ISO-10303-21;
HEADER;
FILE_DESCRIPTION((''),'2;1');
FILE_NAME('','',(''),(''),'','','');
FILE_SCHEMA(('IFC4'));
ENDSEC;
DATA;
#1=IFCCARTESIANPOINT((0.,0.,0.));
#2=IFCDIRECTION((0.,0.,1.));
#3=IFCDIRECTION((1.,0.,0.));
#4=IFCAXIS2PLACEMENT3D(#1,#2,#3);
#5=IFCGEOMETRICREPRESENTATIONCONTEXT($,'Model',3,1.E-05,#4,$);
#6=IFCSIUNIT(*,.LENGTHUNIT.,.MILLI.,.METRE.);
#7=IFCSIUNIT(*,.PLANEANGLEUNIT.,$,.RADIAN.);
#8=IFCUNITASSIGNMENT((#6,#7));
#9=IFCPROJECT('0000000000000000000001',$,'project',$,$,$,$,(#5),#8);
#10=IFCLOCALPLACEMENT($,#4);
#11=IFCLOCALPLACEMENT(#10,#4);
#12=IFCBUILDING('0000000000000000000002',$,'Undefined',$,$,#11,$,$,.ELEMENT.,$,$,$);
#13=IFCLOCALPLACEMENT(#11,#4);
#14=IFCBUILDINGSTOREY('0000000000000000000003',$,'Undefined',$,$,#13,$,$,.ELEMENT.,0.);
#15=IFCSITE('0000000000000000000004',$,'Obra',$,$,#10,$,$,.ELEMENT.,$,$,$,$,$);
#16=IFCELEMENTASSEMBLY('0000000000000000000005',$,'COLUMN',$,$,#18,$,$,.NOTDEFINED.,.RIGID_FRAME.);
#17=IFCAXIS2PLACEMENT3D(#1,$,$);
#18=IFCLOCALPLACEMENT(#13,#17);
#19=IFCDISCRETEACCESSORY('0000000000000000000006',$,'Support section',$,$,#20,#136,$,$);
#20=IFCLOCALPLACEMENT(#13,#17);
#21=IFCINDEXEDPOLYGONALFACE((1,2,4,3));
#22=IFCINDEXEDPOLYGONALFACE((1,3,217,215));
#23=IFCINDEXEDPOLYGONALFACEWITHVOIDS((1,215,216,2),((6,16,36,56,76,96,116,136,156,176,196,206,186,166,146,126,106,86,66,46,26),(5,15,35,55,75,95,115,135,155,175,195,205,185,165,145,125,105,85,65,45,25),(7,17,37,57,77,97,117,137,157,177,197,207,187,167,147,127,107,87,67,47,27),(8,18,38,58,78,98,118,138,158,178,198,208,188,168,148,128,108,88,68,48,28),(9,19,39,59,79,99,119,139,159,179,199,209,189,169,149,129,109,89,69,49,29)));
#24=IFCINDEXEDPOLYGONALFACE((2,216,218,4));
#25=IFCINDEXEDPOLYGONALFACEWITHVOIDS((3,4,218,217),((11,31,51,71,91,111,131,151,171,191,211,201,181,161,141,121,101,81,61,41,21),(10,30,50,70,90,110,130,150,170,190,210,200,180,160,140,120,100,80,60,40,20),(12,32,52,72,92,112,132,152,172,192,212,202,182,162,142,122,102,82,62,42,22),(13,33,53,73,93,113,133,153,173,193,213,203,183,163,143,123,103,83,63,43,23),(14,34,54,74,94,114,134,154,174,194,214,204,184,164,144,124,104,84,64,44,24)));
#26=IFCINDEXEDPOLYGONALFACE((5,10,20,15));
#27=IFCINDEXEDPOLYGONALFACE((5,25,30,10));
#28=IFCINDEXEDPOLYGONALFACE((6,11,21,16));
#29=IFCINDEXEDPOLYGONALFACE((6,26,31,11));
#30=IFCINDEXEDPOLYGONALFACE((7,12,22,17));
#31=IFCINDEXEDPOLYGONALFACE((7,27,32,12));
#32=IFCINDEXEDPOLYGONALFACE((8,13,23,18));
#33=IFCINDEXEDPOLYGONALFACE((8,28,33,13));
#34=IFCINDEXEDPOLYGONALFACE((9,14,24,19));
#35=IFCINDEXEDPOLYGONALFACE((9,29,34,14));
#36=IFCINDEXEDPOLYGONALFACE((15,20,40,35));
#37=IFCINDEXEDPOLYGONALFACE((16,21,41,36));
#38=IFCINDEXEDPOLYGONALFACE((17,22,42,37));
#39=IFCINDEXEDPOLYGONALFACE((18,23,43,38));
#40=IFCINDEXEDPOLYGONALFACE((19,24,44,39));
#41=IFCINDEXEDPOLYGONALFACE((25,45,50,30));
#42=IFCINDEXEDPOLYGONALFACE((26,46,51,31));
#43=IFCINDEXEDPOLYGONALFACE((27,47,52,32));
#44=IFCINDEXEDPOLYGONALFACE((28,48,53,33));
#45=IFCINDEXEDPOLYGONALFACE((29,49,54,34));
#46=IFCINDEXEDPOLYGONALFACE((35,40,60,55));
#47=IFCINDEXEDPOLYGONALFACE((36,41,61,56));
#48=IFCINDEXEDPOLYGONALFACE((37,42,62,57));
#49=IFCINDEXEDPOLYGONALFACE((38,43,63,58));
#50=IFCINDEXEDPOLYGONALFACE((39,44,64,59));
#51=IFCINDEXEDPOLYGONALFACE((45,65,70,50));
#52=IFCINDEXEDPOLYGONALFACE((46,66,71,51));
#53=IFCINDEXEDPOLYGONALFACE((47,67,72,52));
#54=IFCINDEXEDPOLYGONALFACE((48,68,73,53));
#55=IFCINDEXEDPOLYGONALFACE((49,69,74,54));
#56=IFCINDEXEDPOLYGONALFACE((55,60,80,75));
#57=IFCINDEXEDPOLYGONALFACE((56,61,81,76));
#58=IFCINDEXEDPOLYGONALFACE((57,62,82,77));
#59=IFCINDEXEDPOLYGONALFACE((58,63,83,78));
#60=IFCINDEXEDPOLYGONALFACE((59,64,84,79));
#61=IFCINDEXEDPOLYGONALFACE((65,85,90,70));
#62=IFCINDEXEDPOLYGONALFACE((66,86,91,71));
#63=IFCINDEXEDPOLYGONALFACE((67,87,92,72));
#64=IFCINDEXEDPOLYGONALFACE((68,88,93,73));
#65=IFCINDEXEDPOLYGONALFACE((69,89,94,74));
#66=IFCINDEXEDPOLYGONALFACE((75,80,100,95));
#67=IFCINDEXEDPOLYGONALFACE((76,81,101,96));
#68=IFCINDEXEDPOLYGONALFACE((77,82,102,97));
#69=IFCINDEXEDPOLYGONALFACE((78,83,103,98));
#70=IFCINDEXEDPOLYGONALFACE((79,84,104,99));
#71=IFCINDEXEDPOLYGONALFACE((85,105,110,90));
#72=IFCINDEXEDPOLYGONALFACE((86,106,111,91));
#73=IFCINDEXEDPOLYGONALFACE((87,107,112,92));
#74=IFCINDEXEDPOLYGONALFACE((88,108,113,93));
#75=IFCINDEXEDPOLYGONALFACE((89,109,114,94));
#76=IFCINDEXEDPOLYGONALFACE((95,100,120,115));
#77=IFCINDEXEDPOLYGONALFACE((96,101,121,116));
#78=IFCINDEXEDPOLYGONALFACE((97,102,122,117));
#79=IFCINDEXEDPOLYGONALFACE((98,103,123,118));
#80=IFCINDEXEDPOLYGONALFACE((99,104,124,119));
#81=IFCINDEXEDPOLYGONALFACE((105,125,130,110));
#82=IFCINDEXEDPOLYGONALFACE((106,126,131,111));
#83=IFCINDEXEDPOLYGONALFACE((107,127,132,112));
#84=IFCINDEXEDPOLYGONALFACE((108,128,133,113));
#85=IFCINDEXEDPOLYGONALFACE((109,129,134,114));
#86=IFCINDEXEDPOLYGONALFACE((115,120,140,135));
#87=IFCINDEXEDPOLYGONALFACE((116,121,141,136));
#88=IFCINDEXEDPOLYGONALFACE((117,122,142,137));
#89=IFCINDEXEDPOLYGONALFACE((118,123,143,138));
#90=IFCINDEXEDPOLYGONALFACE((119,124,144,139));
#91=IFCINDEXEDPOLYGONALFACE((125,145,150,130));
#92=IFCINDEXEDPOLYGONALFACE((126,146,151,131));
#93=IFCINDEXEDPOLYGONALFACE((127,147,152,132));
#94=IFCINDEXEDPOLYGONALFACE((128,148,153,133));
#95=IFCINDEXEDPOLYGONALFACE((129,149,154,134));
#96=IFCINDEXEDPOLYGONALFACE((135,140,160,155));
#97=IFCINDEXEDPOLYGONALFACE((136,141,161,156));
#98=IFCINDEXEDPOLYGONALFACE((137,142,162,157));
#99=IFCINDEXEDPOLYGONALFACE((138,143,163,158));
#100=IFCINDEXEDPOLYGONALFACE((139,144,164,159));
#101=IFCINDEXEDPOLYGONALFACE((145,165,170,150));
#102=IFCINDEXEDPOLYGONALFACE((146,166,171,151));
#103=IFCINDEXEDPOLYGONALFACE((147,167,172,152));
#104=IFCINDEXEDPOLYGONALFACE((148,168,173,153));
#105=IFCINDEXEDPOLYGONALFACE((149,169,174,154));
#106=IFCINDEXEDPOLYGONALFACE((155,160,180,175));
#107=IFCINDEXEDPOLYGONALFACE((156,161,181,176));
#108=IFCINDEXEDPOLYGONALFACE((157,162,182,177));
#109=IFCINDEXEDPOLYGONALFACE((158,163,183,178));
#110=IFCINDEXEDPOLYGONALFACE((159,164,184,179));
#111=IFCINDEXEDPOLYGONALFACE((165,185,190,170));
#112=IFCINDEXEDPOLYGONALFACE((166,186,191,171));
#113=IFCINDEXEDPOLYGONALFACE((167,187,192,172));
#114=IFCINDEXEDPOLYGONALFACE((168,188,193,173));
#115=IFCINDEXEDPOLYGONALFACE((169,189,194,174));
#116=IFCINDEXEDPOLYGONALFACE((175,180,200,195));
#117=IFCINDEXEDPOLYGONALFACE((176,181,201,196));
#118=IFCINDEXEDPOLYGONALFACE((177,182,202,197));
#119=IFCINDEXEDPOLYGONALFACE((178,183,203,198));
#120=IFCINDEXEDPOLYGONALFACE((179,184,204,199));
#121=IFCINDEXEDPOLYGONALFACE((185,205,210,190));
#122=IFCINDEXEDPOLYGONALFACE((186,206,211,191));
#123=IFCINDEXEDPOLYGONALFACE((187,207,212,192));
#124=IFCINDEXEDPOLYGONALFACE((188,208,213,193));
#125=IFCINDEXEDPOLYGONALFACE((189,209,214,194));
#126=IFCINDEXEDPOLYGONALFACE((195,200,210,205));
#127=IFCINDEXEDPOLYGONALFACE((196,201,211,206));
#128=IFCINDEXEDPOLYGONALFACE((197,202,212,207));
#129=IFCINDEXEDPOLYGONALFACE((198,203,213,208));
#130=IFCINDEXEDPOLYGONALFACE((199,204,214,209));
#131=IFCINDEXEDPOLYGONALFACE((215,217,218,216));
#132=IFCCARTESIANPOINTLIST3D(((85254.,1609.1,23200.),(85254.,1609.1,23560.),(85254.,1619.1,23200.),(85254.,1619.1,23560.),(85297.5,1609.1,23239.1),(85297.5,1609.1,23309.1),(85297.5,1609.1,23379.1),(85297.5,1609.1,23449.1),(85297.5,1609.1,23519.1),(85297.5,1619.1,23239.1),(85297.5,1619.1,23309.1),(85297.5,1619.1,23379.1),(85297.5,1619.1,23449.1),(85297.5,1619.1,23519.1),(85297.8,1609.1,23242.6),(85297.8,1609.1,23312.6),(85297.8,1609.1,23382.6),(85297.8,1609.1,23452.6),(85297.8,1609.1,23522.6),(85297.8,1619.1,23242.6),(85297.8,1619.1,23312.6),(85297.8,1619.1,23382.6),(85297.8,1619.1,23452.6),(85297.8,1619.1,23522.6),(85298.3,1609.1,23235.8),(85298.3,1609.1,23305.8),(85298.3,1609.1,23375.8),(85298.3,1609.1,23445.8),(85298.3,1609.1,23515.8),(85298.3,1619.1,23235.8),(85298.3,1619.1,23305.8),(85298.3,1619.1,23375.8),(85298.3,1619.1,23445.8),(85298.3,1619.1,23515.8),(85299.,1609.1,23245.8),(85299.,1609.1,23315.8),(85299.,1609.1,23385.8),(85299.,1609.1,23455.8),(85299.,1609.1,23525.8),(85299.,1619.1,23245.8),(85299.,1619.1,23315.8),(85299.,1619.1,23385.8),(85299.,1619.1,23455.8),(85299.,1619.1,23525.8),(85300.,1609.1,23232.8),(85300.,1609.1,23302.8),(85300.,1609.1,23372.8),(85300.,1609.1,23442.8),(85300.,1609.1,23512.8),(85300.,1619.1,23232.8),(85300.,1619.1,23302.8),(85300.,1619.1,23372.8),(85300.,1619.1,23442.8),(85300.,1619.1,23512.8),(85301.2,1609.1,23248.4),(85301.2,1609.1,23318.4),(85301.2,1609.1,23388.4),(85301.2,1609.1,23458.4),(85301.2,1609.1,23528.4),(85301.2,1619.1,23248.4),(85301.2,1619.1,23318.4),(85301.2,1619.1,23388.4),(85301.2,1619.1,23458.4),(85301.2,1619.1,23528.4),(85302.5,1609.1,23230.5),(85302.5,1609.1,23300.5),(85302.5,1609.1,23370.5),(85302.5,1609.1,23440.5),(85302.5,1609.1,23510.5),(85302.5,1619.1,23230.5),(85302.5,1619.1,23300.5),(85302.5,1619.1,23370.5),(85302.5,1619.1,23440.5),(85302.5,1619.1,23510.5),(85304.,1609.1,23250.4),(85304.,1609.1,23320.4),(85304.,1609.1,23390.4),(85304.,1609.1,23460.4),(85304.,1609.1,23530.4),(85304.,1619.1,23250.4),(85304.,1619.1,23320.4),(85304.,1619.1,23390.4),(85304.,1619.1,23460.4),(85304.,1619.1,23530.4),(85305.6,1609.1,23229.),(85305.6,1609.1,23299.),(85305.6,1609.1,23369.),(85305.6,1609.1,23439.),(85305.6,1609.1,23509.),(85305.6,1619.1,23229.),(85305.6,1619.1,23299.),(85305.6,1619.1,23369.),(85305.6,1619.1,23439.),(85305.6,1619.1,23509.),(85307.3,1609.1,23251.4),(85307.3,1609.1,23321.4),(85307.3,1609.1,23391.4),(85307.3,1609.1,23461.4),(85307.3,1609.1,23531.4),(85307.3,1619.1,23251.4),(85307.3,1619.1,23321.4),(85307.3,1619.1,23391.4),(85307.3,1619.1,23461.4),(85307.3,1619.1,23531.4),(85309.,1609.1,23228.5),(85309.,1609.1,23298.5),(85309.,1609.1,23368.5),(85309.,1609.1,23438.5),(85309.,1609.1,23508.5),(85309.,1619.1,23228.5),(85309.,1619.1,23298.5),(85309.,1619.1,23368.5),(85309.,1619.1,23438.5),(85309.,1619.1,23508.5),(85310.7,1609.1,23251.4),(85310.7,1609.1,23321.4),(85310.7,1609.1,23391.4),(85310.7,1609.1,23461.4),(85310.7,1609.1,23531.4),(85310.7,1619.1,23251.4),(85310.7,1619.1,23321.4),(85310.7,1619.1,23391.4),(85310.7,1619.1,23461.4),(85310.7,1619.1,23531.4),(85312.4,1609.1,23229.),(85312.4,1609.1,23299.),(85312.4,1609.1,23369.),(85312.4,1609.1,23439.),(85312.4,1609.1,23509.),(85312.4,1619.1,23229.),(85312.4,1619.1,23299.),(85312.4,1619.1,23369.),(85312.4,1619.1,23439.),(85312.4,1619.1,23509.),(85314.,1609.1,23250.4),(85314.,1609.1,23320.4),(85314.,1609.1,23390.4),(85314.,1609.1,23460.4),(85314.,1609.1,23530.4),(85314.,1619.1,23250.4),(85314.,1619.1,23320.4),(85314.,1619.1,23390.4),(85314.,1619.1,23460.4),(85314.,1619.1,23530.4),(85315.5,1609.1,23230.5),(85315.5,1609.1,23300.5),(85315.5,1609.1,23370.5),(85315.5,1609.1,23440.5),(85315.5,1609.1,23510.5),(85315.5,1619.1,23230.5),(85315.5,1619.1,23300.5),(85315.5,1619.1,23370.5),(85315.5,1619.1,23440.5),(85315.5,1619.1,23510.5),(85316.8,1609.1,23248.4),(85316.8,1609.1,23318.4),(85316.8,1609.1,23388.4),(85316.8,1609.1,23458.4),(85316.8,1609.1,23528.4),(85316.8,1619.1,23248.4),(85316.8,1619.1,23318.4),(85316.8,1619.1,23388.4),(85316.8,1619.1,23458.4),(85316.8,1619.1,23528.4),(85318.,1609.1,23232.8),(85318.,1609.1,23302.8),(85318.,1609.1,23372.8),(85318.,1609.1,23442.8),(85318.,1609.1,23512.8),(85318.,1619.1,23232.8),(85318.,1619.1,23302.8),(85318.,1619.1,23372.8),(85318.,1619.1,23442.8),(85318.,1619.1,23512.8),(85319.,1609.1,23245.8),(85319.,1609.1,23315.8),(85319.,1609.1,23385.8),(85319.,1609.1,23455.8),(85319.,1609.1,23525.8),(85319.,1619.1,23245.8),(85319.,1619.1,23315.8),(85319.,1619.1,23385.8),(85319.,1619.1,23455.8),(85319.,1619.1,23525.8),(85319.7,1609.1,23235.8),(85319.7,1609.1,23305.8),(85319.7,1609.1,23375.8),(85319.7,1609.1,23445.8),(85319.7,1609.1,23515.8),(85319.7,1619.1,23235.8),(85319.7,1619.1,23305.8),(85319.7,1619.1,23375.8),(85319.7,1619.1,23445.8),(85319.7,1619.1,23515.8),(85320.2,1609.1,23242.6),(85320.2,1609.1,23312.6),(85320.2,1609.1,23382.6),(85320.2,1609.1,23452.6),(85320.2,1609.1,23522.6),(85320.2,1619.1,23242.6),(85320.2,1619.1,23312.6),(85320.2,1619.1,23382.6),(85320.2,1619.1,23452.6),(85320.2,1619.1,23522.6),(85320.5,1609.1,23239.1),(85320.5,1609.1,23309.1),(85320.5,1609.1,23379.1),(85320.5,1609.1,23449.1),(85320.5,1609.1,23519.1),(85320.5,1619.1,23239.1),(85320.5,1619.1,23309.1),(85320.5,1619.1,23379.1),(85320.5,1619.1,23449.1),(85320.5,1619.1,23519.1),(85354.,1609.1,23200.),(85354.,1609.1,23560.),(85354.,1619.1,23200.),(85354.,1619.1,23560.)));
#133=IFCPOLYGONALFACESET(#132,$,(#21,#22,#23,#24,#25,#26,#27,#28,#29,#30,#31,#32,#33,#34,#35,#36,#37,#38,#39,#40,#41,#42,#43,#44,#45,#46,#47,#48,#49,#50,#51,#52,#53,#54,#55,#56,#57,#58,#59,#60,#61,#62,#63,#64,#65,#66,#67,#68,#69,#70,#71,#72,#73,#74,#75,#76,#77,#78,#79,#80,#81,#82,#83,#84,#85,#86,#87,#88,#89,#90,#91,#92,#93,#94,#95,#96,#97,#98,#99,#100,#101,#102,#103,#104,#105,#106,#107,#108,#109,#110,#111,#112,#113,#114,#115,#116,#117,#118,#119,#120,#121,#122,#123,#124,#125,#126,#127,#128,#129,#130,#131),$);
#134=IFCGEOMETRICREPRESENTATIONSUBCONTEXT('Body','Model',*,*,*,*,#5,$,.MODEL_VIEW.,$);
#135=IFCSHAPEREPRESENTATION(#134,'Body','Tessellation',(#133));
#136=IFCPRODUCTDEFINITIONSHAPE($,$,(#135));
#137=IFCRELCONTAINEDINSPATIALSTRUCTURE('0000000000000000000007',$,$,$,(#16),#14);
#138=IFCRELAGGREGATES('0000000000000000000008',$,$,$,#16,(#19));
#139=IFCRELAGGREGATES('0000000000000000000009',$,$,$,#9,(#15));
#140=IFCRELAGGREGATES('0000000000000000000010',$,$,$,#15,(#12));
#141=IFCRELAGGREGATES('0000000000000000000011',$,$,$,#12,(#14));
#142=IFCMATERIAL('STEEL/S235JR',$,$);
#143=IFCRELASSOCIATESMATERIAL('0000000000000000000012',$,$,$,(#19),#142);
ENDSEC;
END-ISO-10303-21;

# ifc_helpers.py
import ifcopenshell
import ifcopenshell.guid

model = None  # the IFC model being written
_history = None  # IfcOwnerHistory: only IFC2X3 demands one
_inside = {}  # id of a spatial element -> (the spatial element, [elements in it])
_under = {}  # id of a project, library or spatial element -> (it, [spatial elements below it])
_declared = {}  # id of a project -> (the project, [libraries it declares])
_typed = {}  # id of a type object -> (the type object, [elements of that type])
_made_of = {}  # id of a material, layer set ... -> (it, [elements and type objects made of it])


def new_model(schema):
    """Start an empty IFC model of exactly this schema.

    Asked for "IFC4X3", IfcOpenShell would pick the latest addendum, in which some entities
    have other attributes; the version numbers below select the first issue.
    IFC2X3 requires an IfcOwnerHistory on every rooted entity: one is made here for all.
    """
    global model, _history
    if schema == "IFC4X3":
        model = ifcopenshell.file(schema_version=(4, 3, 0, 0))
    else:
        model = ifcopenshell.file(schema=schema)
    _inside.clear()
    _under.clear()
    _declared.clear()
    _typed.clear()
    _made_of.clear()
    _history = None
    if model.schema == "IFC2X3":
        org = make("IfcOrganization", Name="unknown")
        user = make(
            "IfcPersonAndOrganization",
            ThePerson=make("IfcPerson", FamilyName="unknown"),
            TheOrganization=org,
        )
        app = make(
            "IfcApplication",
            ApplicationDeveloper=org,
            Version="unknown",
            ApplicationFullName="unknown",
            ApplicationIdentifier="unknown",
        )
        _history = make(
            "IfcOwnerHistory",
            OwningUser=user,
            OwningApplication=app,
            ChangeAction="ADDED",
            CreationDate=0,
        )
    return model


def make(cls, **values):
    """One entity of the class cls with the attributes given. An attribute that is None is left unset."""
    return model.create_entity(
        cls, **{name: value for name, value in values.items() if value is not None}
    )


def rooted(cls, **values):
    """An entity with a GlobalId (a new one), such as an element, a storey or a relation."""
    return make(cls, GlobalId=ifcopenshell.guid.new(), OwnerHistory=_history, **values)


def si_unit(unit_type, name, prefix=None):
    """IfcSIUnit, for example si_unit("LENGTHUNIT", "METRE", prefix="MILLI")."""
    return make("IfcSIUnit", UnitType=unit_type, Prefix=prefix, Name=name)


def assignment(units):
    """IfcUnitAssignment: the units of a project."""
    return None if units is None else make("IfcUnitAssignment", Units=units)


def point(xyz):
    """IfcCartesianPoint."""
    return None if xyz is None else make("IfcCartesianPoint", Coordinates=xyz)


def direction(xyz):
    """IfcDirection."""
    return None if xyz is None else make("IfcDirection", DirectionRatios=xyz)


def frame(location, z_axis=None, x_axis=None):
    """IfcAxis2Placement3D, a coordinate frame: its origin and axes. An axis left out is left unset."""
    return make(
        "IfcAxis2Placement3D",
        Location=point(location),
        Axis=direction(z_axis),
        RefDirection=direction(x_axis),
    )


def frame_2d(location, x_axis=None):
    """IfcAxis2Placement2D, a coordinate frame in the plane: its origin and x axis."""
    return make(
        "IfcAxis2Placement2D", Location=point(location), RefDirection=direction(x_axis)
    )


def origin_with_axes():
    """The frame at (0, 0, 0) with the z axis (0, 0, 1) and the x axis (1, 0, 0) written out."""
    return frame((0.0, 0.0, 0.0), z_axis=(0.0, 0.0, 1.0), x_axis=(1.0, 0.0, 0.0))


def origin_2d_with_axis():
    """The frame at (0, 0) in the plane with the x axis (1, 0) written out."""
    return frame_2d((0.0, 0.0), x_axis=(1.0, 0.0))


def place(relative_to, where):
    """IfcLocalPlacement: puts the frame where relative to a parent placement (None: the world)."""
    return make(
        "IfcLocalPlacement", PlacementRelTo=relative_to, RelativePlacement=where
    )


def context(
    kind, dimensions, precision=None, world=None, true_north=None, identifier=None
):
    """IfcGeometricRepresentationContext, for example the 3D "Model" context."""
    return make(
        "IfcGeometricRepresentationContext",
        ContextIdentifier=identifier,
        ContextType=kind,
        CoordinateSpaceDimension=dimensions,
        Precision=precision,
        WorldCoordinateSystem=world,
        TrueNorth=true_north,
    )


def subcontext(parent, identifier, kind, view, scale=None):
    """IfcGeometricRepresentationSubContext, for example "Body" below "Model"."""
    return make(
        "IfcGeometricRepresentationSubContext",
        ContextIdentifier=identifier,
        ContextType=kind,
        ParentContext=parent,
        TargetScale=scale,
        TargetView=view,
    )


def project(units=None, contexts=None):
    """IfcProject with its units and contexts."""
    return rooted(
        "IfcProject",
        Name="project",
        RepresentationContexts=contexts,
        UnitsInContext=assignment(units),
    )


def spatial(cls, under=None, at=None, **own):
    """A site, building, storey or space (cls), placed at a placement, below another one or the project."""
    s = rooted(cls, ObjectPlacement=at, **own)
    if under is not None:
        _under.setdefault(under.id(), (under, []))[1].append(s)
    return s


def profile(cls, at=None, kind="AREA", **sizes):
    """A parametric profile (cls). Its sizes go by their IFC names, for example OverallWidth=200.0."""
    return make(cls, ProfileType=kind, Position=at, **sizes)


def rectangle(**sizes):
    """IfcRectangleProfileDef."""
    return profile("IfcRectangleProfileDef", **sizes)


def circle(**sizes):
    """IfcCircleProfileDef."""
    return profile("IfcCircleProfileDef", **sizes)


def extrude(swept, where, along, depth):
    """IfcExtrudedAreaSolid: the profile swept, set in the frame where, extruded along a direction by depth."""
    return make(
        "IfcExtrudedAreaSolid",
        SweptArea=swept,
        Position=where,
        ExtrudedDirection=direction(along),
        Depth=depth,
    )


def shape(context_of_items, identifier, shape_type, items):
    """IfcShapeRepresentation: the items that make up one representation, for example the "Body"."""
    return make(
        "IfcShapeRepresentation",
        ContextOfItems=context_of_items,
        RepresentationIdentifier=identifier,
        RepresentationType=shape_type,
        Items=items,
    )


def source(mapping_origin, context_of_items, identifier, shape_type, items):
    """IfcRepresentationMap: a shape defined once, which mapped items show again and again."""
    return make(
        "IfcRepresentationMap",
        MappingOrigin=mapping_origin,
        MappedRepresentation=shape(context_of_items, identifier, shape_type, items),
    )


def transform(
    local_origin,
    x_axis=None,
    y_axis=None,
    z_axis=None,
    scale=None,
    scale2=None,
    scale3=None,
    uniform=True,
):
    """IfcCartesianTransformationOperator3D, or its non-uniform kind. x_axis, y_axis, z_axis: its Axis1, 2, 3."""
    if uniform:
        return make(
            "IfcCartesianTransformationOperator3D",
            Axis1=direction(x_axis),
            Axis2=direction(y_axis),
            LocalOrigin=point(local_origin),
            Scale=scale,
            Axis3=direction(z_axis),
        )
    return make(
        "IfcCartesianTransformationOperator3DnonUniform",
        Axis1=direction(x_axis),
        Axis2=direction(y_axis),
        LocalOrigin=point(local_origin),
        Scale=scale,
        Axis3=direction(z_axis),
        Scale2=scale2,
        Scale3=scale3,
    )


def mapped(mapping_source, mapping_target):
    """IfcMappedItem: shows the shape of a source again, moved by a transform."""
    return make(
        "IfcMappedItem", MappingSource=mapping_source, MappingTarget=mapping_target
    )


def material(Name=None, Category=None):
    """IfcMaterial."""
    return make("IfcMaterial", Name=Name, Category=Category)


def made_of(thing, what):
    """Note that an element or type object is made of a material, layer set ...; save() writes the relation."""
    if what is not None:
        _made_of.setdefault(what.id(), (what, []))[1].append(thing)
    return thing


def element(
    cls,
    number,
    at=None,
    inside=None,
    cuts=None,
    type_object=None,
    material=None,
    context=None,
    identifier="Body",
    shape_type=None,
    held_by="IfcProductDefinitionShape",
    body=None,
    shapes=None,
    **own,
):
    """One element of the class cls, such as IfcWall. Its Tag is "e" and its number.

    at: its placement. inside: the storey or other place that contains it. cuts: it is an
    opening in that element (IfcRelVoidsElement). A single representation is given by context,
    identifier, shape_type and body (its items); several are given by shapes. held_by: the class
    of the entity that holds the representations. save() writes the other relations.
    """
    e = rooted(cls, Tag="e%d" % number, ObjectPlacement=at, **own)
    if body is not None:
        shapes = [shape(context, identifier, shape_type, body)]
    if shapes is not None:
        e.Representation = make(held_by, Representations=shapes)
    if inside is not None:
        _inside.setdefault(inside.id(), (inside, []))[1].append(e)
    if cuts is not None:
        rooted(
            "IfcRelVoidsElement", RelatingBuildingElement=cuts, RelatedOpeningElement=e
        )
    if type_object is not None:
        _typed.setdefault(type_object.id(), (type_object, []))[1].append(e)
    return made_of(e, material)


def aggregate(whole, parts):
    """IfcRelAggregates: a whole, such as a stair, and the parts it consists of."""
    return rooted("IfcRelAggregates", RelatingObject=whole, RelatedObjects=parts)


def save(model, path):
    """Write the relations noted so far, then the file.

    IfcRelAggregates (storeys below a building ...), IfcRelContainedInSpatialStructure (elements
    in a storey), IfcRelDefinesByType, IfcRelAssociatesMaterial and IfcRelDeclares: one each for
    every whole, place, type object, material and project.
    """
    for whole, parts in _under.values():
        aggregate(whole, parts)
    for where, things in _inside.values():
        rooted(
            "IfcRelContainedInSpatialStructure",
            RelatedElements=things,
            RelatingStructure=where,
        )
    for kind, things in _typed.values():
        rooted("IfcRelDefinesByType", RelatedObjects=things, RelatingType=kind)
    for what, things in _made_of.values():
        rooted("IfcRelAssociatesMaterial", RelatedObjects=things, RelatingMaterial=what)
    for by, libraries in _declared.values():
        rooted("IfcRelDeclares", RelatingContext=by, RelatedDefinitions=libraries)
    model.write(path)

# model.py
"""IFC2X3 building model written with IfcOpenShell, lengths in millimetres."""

from ifc_helpers import new_model, si_unit, frame, origin_with_axes, origin_2d_with_axis, place, context, subcontext, project, spatial, rectangle, circle, extrude, source, transform, mapped, material, element, aggregate, save


model = new_model("IFC2X3")

# Units and contexts
model_context = context("Model", 3, precision=1e-05, world=origin_with_axes())
body_context = subcontext(model_context, "Body", "Model", "MODEL_VIEW")
ifc_project = project(units=[si_unit("LENGTHUNIT", "METRE", prefix="MILLI"), si_unit("PLANEANGLEUNIT", "RADIAN")], contexts=[model_context])

# Site, building, storey
site_placement = place(None, origin_with_axes())
site = spatial("IfcSite", under=ifc_project, at=site_placement, Name="Obra", CompositionType="ELEMENT")
building_placement = place(site_placement, origin_with_axes())
building = spatial("IfcBuilding", under=site, at=building_placement, Name="Undefined", CompositionType="ELEMENT")
storey_placement = place(building_placement, origin_with_axes())
storey = spatial("IfcBuildingStorey", under=building, at=storey_placement, Name="Undefined", CompositionType="ELEMENT", Elevation=0.0)

# Element assembly
assembly_1_placement = place(storey_placement, origin_with_axes())
assembly_1 = element("IfcElementAssembly", 1, at=assembly_1_placement, inside=storey, Name="COLUMN", AssemblyPlace="NOTDEFINED", PredefinedType="RIGID_FRAME")
ifc_material_1 = material(Name="STEEL/S235JR")

# Discrete accessory, opening
discrete_accessory_1_placement = place(assembly_1_placement, frame((85304.0, 1614.1, 23200.0), z_axis=(0.0, 0.0, 1.0), x_axis=(-1.0, 0.0, 0.0)))
discrete_accessory_1 = element("IfcDiscreteAccessory", 2, at=discrete_accessory_1_placement, material=ifc_material_1, Name="Support section", context=body_context, shape_type="SweptSolid", body=[
    extrude(rectangle(XDim=10.0, YDim=100.0, at=origin_2d_with_axis()), frame((0.0, 0.0, 360.0), z_axis=(0.0, 0.0, -1.0), x_axis=(0.0, 1.0, 0.0)), (0.0, 0.0, 1.0), 360.0),
])
shared_shape_1 = source(origin_with_axes(), body_context, "Body", "SweptSolid", [
    extrude(circle(Radius=11.5, at=origin_2d_with_axis()), frame((0.0, 5.7, 0.0), z_axis=(0.0, 1.0, 0.0), x_axis=(1.0, 0.0, 0.0)), (0.0, 0.0, 1.0), 10.2),
])
opening_1_placement = place(assembly_1_placement, frame((85264.0, 1603.4, 23600.0), z_axis=(1.0, 0.0, 0.0), x_axis=(0.0, 0.0, -1.0)))
element("IfcOpeningElement", 3, at=opening_1_placement, cuts=discrete_accessory_1, ObjectType="Opening", context=body_context, shape_type="MappedRepresentation", body=[
    mapped(shared_shape_1, transform((80.0, 0.0, 45.0))),
    mapped(shared_shape_1, transform((150.0, 0.0, 45.0))),
    mapped(shared_shape_1, transform((220.0, 0.0, 45.0))),
    mapped(shared_shape_1, transform((290.0, 0.0, 45.0))),
    mapped(shared_shape_1, transform((360.0, 0.0, 45.0))),
])
aggregate(assembly_1, [discrete_accessory_1])

save(model, "model.ifc")
